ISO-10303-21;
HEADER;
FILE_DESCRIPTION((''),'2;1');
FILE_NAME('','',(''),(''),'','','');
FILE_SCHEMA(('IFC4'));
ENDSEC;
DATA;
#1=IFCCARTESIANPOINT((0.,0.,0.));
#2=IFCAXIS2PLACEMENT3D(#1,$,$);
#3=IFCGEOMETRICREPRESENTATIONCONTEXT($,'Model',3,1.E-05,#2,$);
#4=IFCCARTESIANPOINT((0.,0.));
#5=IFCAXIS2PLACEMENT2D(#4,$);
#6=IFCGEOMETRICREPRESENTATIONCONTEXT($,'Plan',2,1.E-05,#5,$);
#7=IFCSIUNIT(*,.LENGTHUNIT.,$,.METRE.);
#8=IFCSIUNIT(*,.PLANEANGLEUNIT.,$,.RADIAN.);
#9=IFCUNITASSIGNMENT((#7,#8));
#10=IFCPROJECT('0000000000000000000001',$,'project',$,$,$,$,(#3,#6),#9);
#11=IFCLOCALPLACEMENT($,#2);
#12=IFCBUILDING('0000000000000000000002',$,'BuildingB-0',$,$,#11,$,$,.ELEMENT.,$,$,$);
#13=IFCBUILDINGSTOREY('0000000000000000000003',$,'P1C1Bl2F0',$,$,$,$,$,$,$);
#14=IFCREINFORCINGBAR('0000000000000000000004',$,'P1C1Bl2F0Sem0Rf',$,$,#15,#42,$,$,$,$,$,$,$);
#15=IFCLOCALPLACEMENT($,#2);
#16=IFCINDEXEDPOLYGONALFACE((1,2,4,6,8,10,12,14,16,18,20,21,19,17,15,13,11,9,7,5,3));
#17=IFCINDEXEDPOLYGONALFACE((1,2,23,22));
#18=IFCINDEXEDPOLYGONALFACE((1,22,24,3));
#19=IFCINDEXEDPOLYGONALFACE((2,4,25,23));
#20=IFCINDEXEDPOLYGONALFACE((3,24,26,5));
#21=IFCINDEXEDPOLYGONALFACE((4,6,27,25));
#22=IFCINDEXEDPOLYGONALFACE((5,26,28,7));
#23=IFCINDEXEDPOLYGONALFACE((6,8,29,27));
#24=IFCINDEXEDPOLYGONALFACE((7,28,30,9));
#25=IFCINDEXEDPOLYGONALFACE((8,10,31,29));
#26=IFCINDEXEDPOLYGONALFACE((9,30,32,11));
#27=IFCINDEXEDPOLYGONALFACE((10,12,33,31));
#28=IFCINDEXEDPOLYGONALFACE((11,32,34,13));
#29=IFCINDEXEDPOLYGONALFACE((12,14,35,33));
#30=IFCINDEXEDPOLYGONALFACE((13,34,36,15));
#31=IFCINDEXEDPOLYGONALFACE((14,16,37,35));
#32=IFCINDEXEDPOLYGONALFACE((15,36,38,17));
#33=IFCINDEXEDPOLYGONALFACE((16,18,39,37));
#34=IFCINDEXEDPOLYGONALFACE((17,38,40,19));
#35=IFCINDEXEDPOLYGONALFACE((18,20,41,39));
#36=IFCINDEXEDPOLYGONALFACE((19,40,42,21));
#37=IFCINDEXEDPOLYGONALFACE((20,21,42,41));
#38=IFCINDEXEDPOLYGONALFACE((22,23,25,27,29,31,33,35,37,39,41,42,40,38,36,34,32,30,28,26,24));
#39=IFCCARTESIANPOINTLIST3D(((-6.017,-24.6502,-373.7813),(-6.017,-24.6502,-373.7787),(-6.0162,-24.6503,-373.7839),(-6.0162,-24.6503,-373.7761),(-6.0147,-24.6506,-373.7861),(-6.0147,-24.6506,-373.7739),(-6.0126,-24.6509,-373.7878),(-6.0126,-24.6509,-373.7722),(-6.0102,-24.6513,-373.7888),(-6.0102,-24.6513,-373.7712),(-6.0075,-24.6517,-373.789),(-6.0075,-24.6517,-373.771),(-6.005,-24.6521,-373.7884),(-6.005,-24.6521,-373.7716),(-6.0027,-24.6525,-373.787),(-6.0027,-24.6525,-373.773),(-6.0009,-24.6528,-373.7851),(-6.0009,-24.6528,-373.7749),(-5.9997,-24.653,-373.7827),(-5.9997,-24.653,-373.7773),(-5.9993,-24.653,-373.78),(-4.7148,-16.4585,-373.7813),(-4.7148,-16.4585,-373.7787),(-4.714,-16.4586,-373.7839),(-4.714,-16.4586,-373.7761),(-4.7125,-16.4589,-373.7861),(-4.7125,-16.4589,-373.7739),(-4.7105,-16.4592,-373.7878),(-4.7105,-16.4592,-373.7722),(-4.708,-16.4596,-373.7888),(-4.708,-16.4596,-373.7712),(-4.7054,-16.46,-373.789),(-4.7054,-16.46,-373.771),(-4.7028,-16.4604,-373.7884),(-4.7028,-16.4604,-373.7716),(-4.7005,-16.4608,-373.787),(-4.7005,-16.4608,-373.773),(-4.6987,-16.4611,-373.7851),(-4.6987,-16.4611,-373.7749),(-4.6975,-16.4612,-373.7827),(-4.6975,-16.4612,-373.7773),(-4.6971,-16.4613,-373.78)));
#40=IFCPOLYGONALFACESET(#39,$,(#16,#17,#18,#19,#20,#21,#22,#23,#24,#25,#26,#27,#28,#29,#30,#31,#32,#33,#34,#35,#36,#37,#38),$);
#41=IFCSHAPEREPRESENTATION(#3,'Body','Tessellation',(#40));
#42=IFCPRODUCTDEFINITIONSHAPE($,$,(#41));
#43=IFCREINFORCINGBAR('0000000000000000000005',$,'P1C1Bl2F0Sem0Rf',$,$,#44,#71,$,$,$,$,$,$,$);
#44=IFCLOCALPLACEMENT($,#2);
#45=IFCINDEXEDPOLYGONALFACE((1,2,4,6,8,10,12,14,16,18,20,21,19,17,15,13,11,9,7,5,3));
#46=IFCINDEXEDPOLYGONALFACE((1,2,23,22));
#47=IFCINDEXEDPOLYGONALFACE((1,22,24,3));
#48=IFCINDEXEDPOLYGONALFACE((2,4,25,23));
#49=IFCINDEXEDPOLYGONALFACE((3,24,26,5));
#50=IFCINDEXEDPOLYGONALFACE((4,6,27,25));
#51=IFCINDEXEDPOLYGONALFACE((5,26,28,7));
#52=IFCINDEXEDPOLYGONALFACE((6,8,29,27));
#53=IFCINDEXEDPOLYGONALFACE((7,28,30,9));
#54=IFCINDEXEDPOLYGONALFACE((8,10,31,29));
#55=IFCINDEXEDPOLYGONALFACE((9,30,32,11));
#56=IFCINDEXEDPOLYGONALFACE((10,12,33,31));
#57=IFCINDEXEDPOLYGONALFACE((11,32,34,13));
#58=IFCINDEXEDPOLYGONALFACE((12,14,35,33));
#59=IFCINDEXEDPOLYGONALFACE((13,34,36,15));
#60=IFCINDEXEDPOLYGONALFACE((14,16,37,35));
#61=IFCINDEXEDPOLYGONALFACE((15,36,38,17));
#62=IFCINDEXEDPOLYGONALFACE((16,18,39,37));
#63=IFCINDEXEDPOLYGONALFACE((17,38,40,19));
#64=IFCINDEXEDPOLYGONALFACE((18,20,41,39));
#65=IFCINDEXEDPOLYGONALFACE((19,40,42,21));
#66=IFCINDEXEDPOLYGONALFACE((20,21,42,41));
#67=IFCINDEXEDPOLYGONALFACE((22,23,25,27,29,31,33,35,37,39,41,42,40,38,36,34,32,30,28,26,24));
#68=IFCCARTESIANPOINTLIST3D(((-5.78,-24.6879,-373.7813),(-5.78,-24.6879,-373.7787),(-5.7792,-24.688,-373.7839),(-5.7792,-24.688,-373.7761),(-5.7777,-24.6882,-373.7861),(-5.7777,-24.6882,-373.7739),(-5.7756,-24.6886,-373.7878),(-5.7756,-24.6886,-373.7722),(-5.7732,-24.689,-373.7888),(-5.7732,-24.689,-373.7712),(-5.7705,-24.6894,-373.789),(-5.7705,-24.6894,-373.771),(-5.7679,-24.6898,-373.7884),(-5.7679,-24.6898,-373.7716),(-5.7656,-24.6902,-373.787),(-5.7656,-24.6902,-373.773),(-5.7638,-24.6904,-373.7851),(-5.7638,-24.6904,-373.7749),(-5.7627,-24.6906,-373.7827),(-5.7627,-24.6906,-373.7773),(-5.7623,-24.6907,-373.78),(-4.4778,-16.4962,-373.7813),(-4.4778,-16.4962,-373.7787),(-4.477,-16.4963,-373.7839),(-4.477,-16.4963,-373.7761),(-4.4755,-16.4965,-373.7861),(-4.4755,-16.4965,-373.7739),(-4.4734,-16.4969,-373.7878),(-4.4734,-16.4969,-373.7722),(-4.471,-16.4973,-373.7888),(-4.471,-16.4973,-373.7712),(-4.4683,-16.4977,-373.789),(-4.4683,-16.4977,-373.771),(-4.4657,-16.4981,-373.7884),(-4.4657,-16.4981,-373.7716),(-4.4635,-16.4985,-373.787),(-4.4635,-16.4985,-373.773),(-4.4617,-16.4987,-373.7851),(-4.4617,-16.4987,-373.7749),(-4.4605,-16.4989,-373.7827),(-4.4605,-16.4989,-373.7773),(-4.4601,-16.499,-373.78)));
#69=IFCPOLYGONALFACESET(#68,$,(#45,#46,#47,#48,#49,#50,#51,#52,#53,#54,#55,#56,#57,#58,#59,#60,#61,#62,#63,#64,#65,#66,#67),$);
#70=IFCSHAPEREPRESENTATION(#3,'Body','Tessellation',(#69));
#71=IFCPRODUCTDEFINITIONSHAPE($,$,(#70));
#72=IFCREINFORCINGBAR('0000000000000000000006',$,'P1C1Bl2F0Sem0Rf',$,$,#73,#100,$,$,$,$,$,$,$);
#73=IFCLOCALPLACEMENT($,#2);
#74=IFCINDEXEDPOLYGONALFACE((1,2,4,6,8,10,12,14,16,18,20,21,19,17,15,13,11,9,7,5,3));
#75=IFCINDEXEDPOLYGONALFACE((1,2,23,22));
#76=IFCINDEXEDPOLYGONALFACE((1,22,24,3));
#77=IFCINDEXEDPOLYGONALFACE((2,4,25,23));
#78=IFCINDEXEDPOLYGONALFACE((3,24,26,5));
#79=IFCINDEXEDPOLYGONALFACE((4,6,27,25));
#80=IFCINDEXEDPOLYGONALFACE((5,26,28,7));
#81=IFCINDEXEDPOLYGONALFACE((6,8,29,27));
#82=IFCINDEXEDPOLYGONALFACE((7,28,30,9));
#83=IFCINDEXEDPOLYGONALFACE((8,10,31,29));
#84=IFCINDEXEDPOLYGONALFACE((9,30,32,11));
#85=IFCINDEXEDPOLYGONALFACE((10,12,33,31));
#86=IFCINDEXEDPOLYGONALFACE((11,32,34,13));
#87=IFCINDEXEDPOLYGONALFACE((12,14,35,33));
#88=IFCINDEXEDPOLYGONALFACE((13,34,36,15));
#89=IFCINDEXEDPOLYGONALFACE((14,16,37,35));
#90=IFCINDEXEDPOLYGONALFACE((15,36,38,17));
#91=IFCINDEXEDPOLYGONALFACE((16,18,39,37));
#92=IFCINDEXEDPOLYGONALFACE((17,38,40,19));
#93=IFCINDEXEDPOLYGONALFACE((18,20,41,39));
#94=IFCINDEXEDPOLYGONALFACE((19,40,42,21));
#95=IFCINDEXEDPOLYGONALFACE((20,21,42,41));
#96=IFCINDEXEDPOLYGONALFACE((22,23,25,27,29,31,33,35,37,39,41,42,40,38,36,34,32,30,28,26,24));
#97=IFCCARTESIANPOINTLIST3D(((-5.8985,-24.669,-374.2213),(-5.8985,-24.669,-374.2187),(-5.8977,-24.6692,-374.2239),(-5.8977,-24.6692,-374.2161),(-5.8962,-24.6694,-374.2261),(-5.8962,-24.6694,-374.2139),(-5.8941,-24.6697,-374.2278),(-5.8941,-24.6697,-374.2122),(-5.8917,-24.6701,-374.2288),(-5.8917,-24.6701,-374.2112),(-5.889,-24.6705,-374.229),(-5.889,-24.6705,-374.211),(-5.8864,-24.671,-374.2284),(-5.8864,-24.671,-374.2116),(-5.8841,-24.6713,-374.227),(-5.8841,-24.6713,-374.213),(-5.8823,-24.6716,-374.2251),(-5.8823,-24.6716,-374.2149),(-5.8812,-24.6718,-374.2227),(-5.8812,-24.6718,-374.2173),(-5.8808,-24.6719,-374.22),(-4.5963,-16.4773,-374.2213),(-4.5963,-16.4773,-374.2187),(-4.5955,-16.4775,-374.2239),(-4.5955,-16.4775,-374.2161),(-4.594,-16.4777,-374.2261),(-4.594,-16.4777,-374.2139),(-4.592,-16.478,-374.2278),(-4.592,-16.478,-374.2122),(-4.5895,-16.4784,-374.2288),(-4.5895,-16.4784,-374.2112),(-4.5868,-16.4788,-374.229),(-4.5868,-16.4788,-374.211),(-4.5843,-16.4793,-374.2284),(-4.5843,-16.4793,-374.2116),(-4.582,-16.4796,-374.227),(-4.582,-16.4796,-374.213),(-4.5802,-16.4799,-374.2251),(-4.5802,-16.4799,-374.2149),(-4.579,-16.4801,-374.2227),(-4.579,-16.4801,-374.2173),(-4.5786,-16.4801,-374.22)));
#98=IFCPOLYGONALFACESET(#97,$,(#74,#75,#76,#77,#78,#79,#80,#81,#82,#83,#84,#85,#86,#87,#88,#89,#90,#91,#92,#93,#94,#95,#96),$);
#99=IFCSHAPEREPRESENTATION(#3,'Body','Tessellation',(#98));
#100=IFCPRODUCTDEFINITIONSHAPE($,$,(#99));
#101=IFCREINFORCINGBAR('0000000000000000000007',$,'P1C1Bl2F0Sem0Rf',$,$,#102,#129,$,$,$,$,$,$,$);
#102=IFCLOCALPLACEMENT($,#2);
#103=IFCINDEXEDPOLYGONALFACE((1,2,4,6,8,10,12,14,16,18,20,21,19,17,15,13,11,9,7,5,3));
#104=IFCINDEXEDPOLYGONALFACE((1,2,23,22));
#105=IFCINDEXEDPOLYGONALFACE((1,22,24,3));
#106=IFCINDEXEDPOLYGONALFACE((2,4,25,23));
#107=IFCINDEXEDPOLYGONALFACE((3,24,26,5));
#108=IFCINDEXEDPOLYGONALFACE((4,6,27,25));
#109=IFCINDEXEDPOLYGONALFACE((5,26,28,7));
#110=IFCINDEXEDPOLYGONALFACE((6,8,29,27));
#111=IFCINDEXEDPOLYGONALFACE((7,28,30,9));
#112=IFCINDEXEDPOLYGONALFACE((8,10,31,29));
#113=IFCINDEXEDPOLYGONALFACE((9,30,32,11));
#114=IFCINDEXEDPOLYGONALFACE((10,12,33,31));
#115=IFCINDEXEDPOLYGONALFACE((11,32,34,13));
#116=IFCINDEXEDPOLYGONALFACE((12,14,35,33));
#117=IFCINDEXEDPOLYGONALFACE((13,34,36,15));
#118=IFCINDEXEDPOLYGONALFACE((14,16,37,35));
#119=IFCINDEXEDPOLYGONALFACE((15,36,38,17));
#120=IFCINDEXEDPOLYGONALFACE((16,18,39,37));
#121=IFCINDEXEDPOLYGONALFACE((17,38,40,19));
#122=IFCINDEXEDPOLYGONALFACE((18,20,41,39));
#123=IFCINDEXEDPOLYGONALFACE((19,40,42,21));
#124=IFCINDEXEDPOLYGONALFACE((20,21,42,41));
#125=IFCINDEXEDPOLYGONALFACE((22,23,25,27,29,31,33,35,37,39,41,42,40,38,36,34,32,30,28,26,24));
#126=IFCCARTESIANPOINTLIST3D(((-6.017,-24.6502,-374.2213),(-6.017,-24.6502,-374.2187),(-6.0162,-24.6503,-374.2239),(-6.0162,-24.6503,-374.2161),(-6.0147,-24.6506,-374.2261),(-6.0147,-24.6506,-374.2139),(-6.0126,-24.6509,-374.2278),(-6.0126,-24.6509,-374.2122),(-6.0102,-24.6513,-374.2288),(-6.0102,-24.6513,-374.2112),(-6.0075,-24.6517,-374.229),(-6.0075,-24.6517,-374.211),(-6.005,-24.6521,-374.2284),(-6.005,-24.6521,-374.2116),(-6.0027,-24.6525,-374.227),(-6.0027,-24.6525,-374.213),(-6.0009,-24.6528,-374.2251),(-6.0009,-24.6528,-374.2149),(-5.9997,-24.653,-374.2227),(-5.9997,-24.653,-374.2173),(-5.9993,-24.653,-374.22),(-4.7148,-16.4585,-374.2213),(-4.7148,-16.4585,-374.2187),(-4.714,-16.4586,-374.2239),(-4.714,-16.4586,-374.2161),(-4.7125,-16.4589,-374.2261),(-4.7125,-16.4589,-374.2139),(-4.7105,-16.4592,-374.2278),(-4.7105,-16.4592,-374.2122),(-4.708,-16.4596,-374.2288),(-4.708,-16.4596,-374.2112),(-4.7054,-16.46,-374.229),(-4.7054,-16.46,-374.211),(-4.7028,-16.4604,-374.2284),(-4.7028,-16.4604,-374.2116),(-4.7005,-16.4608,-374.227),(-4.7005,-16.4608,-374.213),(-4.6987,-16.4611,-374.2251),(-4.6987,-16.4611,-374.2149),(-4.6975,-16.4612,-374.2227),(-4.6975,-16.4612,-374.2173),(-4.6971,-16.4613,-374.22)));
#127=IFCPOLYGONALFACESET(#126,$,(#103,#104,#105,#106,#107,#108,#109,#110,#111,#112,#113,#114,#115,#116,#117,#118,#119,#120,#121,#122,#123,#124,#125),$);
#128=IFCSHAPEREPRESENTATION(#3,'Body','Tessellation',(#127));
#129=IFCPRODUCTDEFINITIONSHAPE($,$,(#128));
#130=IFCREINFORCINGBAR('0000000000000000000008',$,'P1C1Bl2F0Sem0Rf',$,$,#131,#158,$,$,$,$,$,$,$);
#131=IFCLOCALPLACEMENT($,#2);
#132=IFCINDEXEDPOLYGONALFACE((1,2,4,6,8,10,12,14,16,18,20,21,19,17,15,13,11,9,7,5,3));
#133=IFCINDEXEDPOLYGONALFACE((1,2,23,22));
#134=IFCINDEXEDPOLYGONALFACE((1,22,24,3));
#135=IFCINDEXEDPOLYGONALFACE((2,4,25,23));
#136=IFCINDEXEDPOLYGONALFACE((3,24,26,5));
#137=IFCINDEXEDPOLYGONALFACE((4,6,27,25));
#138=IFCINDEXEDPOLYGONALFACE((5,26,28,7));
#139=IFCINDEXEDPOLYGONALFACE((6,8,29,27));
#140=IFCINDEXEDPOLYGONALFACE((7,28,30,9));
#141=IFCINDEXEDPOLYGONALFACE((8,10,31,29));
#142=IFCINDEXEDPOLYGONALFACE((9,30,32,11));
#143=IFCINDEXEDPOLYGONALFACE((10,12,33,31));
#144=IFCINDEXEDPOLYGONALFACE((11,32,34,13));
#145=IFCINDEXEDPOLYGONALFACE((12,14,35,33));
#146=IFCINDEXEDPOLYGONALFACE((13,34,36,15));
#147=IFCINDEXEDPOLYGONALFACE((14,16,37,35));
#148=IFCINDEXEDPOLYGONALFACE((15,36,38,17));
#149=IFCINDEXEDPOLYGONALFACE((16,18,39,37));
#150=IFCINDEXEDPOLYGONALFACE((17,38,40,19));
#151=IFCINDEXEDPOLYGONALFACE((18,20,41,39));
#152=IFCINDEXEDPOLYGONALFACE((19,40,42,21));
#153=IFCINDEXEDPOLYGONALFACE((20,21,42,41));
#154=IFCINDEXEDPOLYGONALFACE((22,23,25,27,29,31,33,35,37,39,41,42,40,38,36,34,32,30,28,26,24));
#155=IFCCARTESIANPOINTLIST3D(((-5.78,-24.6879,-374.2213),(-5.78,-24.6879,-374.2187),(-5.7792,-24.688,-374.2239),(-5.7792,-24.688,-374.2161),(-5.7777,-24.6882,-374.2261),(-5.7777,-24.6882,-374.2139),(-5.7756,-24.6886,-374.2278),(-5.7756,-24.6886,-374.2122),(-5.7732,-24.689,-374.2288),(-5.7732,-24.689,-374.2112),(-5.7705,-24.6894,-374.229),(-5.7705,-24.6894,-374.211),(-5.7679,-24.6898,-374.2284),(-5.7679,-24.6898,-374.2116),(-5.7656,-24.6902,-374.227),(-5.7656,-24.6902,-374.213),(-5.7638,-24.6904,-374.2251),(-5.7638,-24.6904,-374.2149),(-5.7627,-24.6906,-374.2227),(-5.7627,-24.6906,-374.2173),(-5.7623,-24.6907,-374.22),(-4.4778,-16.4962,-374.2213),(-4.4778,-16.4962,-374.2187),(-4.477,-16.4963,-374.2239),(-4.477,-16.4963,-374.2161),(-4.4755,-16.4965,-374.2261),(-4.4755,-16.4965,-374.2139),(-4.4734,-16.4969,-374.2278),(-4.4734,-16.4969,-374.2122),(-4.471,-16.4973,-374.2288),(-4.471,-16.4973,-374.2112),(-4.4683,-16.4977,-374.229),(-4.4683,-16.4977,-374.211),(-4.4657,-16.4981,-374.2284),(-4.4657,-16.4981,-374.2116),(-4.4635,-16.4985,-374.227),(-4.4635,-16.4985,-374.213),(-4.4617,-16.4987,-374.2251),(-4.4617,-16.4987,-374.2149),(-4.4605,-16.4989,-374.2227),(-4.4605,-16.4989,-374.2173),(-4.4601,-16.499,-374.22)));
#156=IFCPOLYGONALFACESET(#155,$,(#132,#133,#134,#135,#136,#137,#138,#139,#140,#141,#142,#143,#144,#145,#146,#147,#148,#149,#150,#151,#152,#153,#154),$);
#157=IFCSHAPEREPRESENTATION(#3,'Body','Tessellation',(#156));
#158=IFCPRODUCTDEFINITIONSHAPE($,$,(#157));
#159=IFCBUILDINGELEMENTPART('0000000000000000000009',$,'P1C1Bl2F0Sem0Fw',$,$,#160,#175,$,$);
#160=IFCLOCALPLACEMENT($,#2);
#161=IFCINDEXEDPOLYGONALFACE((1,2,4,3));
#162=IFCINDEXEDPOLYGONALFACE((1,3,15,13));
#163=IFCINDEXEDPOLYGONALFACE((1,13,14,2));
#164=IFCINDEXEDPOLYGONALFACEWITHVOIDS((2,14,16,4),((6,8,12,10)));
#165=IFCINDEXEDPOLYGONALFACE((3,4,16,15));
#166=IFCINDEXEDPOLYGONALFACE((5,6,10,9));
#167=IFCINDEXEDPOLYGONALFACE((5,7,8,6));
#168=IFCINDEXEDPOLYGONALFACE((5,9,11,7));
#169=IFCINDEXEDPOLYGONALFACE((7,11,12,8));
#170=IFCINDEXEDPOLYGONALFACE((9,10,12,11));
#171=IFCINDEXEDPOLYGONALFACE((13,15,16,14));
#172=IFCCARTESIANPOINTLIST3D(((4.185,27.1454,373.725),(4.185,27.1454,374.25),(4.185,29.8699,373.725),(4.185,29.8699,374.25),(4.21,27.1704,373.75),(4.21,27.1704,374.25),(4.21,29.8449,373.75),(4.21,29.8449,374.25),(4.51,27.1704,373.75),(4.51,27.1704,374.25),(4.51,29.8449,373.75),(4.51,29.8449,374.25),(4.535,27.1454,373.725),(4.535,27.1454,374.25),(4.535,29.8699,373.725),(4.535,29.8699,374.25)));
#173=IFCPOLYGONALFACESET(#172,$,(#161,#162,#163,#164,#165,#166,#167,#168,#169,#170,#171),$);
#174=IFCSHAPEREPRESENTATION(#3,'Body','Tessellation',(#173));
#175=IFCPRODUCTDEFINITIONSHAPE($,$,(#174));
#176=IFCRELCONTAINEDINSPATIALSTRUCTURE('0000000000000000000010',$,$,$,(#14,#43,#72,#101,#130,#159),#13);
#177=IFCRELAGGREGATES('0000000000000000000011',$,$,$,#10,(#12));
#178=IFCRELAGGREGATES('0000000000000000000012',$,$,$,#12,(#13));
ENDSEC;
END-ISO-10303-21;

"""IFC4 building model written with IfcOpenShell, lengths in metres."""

from ifc_helpers import new_model, entity, si_unit, origin, origin_2d, place, context, project, spatial, polyline, outline, extrude, element, save


model = new_model("IFC4")

# Units and contexts
model_context = context("Model", 3, precision=1e-05, world=origin())
plan_context = context("Plan", 2, precision=1e-05, world=origin_2d())
ifc_project = project(units=[si_unit("LENGTHUNIT", "METRE"), si_unit("PLANEANGLEUNIT", "RADIAN")], contexts=[model_context, plan_context])

# Building, storey
building_placement = place(None, origin())
building = spatial("IfcBuilding", under=ifc_project, at=building_placement, Name="BuildingB-0", CompositionType="ELEMENT")
storey = spatial("IfcBuildingStorey", under=building, Name="P1C1Bl2F0")

# Reinforcing bars
element("IfcReinforcingBar", 1, inside=storey, Name="P1C1Bl2F0Sem0Rf", context=model_context, shape_type="SweptSolid", body=[
    entity("IfcSurfaceCurveSweptAreaSolid", entity("IfcCircleProfileDef", "AREA", None, None, 0.009), None, entity("IfcPolyline", [entity("IfcCartesianPoint", [4.706, 16.4599, 373.78]), entity("IfcCartesianPoint", [6.0082, 24.6516, 373.78])]), None, None, entity("IfcPlane", entity("IfcAxis2Placement3D", entity("IfcCartesianPoint", [4.706, 16.4599, 373.78]), entity("IfcDirection", [0.0, 0.0, 1.0]), entity("IfcDirection", [1.0, 0.0, 0.0])))),
])
element("IfcReinforcingBar", 2, inside=storey, Name="P1C1Bl2F0Sem0Rf", context=model_context, shape_type="SweptSolid", body=[
    entity("IfcSurfaceCurveSweptAreaSolid", entity("IfcCircleProfileDef", "AREA", None, None, 0.009), None, entity("IfcPolyline", [entity("IfcCartesianPoint", [4.469, 16.4976, 373.78]), entity("IfcCartesianPoint", [5.7712, 24.6893, 373.78])]), None, None, entity("IfcPlane", entity("IfcAxis2Placement3D", entity("IfcCartesianPoint", [4.469, 16.4976, 373.78]), entity("IfcDirection", [0.0, 0.0, 1.0]), entity("IfcDirection", [1.0, 0.0, 0.0])))),
])
element("IfcReinforcingBar", 3, inside=storey, Name="P1C1Bl2F0Sem0Rf", context=model_context, shape_type="SweptSolid", body=[
    entity("IfcSurfaceCurveSweptAreaSolid", entity("IfcCircleProfileDef", "AREA", None, None, 0.009), None, entity("IfcPolyline", [entity("IfcCartesianPoint", [4.5875, 16.4787, 374.22]), entity("IfcCartesianPoint", [5.8897, 24.6704, 374.22])]), None, None, entity("IfcPlane", entity("IfcAxis2Placement3D", entity("IfcCartesianPoint", [4.5875, 16.4787, 374.22]), entity("IfcDirection", [0.0, 0.0, 1.0]), entity("IfcDirection", [1.0, 0.0, 0.0])))),
])
element("IfcReinforcingBar", 4, inside=storey, Name="P1C1Bl2F0Sem0Rf", context=model_context, shape_type="SweptSolid", body=[
    entity("IfcSurfaceCurveSweptAreaSolid", entity("IfcCircleProfileDef", "AREA", None, None, 0.009), None, entity("IfcPolyline", [entity("IfcCartesianPoint", [4.706, 16.4599, 374.22]), entity("IfcCartesianPoint", [6.0082, 24.6516, 374.22])]), None, None, entity("IfcPlane", entity("IfcAxis2Placement3D", entity("IfcCartesianPoint", [4.706, 16.4599, 374.22]), entity("IfcDirection", [0.0, 0.0, 1.0]), entity("IfcDirection", [1.0, 0.0, 0.0])))),
])
element("IfcReinforcingBar", 5, inside=storey, Name="P1C1Bl2F0Sem0Rf", context=model_context, shape_type="SweptSolid", body=[
    entity("IfcSurfaceCurveSweptAreaSolid", entity("IfcCircleProfileDef", "AREA", None, None, 0.009), None, entity("IfcPolyline", [entity("IfcCartesianPoint", [4.469, 16.4976, 374.22]), entity("IfcCartesianPoint", [5.7712, 24.6893, 374.22])]), None, None, entity("IfcPlane", entity("IfcAxis2Placement3D", entity("IfcCartesianPoint", [4.469, 16.4976, 374.22]), entity("IfcDirection", [0.0, 0.0, 1.0]), entity("IfcDirection", [1.0, 0.0, 0.0])))),
])

# Building element part, opening
building_element_part_1 = element("IfcBuildingElementPart", 6, inside=storey, Name="P1C1Bl2F0Sem0Fw", context=model_context, shape_type="SweptSolid", body=[
    extrude(outline(polyline([(4.535, 27.1454, 373.725), (4.185, 27.1454, 373.725), (4.185, 29.8699, 373.725), (4.535, 29.8699, 373.725), (4.535, 27.1454, 373.725)])), None, (0.0, 0.0, 1.0), 0.525),
])
element("IfcOpeningElement", 7, inside=storey, cuts=building_element_part_1, context=model_context, shape_type="SweptSolid", body=[
    extrude(outline(polyline([(4.51, 27.1704, 373.75), (4.21, 27.1704, 373.75), (4.21, 29.8449, 373.75), (4.51, 29.8449, 373.75), (4.51, 27.1704, 373.75)])), None, (0.0, 0.0, 1.0), 0.5),
])

save(model, "model.ifc")
